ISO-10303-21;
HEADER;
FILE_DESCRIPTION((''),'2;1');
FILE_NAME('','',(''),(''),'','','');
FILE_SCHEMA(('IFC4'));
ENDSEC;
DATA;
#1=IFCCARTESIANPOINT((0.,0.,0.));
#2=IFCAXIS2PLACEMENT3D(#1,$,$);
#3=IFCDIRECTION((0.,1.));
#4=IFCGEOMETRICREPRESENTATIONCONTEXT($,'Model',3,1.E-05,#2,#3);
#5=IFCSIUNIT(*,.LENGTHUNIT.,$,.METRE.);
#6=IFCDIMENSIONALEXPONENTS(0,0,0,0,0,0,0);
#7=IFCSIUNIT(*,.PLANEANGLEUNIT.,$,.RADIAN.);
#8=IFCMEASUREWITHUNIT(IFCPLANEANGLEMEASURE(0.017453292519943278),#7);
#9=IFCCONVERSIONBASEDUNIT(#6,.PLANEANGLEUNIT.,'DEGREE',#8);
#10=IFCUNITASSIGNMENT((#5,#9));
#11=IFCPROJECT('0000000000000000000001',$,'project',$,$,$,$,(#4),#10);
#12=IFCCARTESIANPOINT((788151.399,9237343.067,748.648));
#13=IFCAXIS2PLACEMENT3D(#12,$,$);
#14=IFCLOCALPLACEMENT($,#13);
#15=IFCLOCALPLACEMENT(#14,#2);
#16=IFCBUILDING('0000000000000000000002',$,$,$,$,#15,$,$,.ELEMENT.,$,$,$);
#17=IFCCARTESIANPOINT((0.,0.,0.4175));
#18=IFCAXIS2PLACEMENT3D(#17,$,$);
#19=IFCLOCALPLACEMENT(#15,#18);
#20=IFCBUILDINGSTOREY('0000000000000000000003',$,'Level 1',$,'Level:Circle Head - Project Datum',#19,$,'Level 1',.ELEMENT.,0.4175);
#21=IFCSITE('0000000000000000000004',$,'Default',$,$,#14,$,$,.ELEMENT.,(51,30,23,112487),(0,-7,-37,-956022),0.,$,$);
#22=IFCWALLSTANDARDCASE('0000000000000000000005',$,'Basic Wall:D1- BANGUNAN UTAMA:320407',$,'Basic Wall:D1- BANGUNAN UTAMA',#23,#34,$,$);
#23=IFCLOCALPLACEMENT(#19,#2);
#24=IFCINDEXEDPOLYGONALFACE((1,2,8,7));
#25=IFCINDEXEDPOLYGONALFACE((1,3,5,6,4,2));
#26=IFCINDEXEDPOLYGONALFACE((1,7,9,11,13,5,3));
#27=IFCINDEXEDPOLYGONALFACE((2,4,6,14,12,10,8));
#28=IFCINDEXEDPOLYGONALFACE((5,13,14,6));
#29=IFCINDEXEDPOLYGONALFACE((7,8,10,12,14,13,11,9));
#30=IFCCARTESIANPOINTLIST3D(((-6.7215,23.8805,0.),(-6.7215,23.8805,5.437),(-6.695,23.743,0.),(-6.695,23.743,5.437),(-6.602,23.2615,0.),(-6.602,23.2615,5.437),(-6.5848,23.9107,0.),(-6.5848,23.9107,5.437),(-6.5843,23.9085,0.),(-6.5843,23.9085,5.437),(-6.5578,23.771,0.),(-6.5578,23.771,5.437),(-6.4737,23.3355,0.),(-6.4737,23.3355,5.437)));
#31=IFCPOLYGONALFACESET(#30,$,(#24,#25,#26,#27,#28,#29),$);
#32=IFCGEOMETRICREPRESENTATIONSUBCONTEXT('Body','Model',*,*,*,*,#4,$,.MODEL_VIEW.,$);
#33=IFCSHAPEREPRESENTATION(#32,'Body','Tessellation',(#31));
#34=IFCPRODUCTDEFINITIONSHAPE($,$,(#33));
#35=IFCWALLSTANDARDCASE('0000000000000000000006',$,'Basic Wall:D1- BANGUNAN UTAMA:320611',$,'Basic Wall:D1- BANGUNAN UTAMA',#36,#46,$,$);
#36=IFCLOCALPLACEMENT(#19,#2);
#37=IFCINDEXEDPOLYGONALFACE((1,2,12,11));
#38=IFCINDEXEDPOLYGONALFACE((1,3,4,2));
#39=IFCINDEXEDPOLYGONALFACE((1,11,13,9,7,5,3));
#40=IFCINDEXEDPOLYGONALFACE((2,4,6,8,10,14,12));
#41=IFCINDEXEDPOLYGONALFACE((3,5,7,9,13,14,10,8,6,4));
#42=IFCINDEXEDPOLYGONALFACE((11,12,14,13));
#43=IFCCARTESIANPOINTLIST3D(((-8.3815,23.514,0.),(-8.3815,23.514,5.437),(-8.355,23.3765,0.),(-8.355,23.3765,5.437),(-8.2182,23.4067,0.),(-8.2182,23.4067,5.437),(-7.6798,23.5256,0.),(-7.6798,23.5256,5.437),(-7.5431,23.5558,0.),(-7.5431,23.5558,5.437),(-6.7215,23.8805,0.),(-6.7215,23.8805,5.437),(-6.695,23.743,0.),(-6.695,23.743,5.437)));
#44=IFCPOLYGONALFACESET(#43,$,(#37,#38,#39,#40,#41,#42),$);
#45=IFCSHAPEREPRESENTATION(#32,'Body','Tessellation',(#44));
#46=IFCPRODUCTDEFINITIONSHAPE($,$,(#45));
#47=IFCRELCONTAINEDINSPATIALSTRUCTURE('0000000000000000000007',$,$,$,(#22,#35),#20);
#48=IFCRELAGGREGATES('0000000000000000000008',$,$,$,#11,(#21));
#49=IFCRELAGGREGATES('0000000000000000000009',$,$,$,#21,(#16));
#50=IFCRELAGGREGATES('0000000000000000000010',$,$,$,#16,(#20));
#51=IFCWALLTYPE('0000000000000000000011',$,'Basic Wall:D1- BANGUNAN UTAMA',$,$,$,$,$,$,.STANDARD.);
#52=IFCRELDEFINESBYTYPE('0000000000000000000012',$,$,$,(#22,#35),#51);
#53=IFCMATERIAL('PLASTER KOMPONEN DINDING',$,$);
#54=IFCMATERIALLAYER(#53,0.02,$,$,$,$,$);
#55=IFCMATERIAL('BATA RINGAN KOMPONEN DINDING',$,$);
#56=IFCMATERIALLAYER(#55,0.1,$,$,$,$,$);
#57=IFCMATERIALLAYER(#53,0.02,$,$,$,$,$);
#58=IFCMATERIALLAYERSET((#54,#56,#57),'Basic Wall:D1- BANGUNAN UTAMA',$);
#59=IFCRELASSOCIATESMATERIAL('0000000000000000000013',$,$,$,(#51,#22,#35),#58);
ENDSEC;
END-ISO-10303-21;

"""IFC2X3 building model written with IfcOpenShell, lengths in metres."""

from ifc_helpers import new_model, entity, si_unit, converted_unit, direction, frame, origin, place, context, subcontext, project, spatial, polyline, outline, extrude, material, layer, layer_set, layer_usage, type_object, element, save


model = new_model("IFC2X3")

# Units and contexts
model_context = context("Model", 3, precision=1e-05, world=origin(), true_north=direction((0.0, 1.0)))
body_context = subcontext(model_context, "Body", "Model", "MODEL_VIEW")
ifc_project = project(units=[si_unit("LENGTHUNIT", "METRE"), converted_unit("PLANEANGLEUNIT", "DEGREE", entity("IfcPlaneAngleMeasure", 0.017453292519943278), si_unit("PLANEANGLEUNIT", "RADIAN"), dimensions=[0, 0, 0, 0, 0, 0, 0])], contexts=[model_context])

# Site, building, storey
site_placement = place(None, frame((788151.399, 9237343.067, 748.648)))
site = spatial("IfcSite", under=ifc_project, at=site_placement, Name="Default", CompositionType="ELEMENT", RefLatitude=(51, 30, 23, 112487), RefLongitude=(0, -7, -37, -956022), RefElevation=0.0)
building_placement = place(site_placement, origin())
building = spatial("IfcBuilding", under=site, at=building_placement, CompositionType="ELEMENT")
storey_placement = place(building_placement, frame((0.0, 0.0, 0.4175)))
storey = spatial("IfcBuildingStorey", under=building, at=storey_placement, Name="Level 1", ObjectType="Level:Circle Head - Project Datum", LongName="Level 1", CompositionType="ELEMENT", Elevation=0.4175)

# Walls
ifc_material_1 = material(Name="PLASTER KOMPONEN DINDING")
ifc_layer_1 = layer(ifc_material_1, 0.02)
ifc_material_2 = material(Name="BATA RINGAN KOMPONEN DINDING")
ifc_layer_2 = layer(ifc_material_2, 0.1)
ifc_layer_3 = layer(ifc_material_1, 0.02)
ifc_layer_set_1 = layer_set([ifc_layer_1, ifc_layer_2, ifc_layer_3], Name="Basic Wall:D1- BANGUNAN UTAMA")
ifc_layer_usage_1 = layer_usage(ifc_layer_set_1, "AXIS2", "NEGATIVE", 0.07)
wall_type_1 = type_object("IfcWallType", Name="Basic Wall:D1- BANGUNAN UTAMA", PredefinedType="STANDARD", material=ifc_layer_set_1)
wall_1_placement = place(storey_placement, frame((-6.5332, 23.2747, 0.0), z_axis=(0.0, 0.0, 1.0), x_axis=(-0.189641, 0.981853, 0.0)))
element("IfcWallStandardCase", 1, at=wall_1_placement, inside=storey, type_object=wall_type_1, material=ifc_layer_usage_1, Name="Basic Wall:D1- BANGUNAN UTAMA:320407", ObjectType="Basic Wall:D1- BANGUNAN UTAMA", context=body_context, shape_type="SweptSolid", body=[
    extrude(outline(polyline([(0.6342, -0.07), (0.6305, 0.07), (0.4905, 0.07), (0.0, 0.07), (0.0484, -0.07), (0.492, -0.07), (0.632, -0.07), (0.6342, -0.07)])), origin(), (0.0, 0.0, 1.0), 5.437),
])
ifc_layer_usage_2 = layer_usage(ifc_layer_set_1, "AXIS2", "NEGATIVE", 0.07)
wall_2_placement = place(storey_placement, frame((-6.7064, 23.8122, 0.0), z_axis=(0.0, 0.0, 1.0), x_axis=(-0.976481, -0.215604, 0.0)))
element("IfcWallStandardCase", 2, at=wall_2_placement, inside=storey, type_object=wall_type_1, material=ifc_layer_usage_2, Name="Basic Wall:D1- BANGUNAN UTAMA:320611", ObjectType="Basic Wall:D1- BANGUNAN UTAMA", context=body_context, shape_type="SweptSolid", body=[
    extrude(outline(polyline([(1.7, -0.07), (1.7037, 0.07), (1.5637, 0.07), (1.0122, 0.07), (0.8722, 0.07), (0.0037, 0.07), (0.0, -0.07), (1.7, -0.07)])), origin(), (0.0, 0.0, 1.0), 5.437),
])

save(model, "model.ifc")
